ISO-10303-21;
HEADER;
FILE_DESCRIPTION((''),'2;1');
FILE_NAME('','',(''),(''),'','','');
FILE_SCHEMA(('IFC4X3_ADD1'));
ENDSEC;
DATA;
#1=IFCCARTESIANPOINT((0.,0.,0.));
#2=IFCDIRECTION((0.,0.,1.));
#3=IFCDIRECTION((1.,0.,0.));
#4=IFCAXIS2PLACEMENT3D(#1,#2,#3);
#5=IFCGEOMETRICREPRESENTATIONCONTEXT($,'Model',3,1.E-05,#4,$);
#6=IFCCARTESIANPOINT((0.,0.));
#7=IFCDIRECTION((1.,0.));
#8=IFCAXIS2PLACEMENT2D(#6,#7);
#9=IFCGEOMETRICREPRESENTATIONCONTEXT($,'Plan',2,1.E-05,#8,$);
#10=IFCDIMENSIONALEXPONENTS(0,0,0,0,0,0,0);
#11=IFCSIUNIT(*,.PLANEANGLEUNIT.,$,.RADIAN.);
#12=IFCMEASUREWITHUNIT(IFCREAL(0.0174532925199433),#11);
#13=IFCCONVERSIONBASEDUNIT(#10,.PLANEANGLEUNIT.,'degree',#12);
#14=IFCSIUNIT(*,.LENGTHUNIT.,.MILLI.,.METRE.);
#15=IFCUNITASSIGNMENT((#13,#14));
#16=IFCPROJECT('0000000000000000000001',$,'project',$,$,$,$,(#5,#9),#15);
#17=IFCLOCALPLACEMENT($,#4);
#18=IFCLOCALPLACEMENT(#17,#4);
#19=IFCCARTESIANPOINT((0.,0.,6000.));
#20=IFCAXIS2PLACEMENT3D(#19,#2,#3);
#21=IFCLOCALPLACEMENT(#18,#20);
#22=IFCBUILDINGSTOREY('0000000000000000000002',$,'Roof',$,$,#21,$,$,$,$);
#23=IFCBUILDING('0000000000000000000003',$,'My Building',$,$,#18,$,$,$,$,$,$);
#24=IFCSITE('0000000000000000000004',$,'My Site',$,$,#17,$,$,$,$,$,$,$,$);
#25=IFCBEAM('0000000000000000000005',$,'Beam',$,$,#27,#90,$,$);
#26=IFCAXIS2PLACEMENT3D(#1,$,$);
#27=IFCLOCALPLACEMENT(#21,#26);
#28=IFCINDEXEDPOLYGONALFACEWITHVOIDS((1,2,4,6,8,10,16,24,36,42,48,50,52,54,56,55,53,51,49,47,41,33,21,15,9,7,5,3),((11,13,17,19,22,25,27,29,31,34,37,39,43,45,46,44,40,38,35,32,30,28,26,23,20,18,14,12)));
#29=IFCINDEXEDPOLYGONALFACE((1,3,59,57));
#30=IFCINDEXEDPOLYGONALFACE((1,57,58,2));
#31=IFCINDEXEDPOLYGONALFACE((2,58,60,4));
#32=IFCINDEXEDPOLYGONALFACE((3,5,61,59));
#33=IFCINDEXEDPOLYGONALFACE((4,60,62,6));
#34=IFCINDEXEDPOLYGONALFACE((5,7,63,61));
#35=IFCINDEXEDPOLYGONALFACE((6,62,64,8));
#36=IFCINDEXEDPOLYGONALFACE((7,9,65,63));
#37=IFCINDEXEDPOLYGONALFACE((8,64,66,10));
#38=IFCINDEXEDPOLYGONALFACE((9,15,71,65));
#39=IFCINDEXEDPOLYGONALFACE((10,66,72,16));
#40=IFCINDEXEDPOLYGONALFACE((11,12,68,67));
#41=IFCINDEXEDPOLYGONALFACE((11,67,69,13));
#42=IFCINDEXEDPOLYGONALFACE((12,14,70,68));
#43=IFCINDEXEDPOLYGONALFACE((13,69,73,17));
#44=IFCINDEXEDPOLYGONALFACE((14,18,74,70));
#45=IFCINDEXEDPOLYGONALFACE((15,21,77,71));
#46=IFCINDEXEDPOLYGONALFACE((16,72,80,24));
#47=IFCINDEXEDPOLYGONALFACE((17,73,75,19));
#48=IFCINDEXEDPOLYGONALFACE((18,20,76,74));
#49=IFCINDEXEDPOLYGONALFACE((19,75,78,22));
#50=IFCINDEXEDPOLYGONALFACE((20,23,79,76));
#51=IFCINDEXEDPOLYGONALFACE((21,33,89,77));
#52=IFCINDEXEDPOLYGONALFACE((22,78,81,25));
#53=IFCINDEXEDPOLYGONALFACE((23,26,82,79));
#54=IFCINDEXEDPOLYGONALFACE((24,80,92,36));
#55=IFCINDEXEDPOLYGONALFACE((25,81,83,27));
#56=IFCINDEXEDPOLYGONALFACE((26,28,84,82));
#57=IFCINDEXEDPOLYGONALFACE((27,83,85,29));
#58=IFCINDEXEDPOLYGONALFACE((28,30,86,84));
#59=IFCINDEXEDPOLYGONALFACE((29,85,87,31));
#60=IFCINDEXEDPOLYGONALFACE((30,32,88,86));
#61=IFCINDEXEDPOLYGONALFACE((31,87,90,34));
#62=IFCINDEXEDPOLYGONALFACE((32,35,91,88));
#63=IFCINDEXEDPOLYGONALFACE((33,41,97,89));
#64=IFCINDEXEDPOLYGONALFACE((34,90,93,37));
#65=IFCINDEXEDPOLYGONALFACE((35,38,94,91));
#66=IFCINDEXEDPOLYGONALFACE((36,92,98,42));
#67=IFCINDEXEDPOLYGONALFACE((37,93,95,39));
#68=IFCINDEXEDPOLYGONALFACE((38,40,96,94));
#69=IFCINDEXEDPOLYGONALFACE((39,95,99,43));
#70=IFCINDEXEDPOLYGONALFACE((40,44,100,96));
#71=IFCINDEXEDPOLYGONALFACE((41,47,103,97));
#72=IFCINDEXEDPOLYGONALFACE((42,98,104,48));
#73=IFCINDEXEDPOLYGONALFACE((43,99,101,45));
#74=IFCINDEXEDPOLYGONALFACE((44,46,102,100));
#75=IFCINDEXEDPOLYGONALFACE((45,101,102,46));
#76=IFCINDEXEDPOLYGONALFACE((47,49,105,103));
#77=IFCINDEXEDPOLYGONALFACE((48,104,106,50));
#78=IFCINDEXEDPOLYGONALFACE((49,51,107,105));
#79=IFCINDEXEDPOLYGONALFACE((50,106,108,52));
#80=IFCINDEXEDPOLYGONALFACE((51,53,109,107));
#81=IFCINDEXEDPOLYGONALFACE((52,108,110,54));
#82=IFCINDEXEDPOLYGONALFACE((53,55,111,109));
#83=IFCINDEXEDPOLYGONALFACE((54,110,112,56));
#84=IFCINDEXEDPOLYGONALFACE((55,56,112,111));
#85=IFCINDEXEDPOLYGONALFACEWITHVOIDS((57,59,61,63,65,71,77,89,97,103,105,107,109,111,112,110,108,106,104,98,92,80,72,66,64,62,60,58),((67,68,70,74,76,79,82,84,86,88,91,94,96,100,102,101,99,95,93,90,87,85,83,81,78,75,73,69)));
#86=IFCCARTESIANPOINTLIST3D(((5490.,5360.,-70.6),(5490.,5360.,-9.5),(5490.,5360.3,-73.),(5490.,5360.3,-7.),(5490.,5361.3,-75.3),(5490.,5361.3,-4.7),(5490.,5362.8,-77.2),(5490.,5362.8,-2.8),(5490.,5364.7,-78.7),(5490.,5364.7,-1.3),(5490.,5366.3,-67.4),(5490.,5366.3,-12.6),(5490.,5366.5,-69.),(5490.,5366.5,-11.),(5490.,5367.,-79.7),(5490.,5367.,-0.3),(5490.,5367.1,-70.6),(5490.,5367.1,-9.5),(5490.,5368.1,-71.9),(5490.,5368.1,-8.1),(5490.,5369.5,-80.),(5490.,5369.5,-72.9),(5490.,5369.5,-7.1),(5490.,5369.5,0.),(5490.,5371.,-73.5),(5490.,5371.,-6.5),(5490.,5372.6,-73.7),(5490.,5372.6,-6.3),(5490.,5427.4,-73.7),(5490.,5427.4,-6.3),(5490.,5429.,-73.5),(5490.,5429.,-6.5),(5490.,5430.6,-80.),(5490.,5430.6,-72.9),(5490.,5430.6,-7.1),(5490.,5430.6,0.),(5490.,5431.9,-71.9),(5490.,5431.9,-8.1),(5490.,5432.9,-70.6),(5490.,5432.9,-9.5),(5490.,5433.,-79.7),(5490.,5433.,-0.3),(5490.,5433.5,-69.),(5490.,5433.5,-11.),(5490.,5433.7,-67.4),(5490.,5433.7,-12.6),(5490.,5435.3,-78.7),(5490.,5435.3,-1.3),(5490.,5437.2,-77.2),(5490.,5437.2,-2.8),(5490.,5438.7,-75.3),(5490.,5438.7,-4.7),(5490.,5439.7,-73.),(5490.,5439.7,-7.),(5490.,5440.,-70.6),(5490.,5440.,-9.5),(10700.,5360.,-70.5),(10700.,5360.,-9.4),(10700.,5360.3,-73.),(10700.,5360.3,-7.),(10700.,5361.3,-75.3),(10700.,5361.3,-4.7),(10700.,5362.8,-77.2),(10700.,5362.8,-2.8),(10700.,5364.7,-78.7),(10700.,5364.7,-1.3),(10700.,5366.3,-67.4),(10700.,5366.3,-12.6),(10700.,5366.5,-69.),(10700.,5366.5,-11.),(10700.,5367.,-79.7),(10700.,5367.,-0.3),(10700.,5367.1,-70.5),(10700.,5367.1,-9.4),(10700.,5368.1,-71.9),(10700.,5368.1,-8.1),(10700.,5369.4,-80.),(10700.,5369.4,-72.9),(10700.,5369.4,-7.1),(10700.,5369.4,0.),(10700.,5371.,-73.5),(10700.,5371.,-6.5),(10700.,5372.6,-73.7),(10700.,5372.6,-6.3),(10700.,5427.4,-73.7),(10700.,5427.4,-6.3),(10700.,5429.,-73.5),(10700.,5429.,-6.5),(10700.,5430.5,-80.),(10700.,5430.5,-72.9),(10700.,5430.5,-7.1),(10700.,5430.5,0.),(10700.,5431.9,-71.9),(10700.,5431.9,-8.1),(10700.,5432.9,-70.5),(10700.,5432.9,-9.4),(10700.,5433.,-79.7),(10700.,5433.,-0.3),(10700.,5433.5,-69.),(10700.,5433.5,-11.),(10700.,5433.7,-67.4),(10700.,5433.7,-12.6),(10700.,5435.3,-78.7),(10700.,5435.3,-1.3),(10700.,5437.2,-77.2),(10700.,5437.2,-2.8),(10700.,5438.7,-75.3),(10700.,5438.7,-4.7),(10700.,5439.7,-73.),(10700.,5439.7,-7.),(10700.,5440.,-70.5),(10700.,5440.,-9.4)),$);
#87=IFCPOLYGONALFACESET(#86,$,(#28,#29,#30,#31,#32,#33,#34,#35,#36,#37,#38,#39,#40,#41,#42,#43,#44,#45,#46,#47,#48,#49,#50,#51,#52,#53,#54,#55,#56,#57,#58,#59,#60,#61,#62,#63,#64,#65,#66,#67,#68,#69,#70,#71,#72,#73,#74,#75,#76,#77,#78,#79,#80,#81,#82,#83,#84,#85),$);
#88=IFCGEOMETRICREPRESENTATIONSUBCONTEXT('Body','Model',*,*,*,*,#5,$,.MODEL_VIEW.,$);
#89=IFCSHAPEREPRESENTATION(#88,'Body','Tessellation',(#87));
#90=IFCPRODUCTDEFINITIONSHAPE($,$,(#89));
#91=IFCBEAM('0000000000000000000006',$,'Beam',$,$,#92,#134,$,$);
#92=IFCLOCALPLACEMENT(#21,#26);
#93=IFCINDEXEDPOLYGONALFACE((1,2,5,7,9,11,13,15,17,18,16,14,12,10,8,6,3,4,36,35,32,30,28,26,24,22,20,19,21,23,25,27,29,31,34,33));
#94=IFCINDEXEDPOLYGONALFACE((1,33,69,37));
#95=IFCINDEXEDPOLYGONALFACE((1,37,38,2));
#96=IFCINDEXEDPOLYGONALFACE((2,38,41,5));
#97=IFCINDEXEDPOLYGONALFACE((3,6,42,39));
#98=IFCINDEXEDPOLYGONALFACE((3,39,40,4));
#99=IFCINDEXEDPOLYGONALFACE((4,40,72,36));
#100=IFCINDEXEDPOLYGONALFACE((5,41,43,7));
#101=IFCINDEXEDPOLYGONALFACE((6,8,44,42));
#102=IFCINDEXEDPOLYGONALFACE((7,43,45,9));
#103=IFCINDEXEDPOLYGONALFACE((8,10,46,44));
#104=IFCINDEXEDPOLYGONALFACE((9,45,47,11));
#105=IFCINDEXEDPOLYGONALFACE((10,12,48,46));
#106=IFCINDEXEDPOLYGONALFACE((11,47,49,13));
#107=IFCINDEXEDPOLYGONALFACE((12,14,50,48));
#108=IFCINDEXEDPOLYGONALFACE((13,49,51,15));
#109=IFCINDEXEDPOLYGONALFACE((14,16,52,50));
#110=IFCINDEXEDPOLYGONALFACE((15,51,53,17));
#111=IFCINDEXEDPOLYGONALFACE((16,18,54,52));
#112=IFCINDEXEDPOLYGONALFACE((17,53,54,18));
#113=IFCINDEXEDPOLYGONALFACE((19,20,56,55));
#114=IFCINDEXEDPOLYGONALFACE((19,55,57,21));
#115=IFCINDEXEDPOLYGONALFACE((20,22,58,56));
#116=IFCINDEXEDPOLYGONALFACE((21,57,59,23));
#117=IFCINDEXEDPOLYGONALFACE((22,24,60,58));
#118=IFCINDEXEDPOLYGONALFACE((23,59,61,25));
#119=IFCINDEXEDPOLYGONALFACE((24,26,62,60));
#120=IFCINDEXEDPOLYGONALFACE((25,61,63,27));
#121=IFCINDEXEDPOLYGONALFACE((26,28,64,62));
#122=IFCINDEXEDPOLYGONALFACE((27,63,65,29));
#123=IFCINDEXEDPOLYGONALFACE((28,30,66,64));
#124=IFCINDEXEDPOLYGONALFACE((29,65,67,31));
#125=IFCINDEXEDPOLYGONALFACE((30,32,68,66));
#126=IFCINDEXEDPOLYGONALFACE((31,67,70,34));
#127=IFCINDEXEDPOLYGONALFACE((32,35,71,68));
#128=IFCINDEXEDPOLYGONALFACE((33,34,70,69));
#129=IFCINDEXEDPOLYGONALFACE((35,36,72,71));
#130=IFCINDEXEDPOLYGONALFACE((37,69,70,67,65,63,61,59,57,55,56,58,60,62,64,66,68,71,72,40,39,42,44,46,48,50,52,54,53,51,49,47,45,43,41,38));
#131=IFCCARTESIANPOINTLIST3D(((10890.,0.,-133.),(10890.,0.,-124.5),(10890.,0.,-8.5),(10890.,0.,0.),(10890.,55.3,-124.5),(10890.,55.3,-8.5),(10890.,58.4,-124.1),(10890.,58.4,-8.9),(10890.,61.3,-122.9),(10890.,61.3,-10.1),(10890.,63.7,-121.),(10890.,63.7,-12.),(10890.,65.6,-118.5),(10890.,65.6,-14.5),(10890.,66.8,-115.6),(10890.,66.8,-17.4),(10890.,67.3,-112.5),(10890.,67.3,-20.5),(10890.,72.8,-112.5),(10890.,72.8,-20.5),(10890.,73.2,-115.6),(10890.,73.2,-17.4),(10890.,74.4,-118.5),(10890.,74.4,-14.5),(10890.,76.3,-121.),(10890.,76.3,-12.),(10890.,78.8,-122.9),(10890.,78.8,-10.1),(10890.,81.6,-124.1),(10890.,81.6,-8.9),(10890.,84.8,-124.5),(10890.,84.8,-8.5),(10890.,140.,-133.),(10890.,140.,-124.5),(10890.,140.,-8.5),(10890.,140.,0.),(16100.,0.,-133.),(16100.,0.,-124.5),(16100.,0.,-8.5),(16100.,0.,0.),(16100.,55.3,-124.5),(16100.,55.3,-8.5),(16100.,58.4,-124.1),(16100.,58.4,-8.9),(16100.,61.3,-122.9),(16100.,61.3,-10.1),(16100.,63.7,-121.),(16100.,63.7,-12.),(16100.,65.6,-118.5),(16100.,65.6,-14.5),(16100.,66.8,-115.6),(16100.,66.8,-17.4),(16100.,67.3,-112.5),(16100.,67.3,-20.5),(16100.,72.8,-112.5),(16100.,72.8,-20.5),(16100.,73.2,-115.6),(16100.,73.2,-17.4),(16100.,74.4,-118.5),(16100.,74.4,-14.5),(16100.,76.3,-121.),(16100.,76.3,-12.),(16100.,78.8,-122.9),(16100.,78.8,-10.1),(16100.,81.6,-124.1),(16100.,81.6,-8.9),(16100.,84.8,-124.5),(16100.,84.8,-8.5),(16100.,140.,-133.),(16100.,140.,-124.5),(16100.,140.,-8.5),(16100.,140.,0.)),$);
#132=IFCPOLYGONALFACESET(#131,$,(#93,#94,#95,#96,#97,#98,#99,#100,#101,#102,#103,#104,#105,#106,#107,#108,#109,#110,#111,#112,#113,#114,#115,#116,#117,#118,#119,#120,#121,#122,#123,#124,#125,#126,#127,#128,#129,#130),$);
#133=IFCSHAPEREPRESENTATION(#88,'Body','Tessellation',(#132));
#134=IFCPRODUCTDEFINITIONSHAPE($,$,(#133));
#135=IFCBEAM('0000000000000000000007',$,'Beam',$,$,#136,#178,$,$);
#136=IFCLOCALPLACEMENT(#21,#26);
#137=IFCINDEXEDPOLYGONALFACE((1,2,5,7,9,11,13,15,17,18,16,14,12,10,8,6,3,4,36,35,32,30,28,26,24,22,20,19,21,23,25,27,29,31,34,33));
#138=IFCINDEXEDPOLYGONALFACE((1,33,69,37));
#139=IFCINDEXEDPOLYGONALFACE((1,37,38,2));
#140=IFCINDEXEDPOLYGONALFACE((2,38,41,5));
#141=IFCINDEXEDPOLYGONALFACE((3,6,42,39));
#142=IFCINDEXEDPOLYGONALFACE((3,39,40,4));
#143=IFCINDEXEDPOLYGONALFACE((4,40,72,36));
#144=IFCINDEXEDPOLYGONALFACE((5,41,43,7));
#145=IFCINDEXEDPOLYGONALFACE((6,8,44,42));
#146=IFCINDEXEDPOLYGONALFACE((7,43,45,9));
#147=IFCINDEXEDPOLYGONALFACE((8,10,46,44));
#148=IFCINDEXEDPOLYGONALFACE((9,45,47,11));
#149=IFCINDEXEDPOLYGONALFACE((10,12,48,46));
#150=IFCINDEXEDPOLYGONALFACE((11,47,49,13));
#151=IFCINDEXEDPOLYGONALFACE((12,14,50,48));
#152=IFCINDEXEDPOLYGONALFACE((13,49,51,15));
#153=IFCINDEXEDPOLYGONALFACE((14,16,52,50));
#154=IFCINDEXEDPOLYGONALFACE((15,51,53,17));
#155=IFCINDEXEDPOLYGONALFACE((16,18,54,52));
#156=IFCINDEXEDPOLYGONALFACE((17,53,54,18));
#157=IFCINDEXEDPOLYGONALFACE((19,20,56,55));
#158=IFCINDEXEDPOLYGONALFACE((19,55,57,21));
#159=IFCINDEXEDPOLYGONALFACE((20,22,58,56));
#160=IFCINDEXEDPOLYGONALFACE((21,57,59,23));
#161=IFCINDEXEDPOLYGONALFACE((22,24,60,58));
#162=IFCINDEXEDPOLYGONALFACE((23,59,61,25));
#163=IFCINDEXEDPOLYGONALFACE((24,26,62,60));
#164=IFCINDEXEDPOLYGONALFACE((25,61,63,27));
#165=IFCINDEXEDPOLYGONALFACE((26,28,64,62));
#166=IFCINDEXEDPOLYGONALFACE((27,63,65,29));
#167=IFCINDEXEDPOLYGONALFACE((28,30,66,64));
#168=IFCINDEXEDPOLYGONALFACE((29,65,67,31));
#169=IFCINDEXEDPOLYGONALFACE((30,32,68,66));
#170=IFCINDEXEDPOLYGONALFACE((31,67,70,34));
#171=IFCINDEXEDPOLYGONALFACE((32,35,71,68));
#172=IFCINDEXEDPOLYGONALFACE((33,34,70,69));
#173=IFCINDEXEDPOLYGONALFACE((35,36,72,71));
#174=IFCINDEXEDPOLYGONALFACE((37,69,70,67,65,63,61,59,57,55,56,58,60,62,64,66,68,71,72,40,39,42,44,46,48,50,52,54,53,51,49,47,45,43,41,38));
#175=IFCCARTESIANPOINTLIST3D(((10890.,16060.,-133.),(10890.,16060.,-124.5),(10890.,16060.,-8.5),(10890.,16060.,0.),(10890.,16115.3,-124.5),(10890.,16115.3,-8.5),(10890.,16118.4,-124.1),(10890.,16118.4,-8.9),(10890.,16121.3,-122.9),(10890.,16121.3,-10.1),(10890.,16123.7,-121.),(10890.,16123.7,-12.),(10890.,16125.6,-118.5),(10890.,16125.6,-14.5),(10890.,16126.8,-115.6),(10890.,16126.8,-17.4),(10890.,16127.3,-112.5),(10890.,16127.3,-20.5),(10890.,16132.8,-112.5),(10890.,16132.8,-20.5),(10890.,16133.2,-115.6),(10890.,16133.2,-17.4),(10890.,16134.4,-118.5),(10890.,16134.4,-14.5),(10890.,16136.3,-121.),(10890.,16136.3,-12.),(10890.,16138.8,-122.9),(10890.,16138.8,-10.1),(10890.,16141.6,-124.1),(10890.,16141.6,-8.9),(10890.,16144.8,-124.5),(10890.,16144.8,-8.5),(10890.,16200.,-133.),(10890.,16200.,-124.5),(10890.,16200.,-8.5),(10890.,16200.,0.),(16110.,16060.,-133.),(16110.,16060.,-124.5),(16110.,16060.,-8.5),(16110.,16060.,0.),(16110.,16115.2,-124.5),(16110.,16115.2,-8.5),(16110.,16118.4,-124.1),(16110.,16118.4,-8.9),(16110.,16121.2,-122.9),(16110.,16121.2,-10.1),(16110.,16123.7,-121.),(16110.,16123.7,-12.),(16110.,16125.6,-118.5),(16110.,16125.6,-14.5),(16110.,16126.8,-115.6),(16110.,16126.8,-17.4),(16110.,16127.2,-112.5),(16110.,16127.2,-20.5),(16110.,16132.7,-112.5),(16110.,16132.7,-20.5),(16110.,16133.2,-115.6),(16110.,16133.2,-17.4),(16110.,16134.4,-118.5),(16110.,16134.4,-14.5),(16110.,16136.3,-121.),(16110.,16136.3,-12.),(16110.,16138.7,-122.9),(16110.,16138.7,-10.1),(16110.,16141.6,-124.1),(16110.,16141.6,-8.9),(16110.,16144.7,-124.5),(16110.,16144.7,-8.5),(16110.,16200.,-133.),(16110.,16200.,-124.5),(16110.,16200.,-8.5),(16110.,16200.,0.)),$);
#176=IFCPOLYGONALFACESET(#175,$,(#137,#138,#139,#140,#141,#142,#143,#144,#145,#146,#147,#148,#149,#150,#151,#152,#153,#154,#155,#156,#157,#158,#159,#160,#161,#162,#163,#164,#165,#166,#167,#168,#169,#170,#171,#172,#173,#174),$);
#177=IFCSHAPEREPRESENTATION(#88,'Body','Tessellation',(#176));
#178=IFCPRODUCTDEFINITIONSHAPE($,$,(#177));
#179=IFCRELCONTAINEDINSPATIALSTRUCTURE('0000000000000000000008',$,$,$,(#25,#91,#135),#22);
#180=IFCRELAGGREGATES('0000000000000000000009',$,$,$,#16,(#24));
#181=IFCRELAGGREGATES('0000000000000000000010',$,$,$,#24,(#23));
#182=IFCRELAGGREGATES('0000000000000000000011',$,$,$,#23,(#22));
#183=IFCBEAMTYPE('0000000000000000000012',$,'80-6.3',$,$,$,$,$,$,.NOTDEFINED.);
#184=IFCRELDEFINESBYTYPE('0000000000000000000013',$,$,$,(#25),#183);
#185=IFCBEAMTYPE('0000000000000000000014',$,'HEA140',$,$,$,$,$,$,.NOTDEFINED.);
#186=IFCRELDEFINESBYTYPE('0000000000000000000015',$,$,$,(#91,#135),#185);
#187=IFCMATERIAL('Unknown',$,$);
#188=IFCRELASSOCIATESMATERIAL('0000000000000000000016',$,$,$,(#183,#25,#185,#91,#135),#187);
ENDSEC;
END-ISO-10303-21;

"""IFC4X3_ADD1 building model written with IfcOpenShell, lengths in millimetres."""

from ifc_helpers import new_model, entity, si_unit, converted_unit, frame, origin_with_axes, origin_2d_with_axis, place, context, subcontext, project, spatial, hollow_rectangle, i_section, extrude, material, material_profile, profile_set, profile_usage, type_object, element, save


model = new_model("IFC4X3_ADD1")

# Units and contexts
model_context = context("Model", 3, precision=1e-05, world=origin_with_axes())
plan_context = context("Plan", 2, precision=1e-05, world=origin_2d_with_axis())
body_context = subcontext(model_context, "Body", "Model", "MODEL_VIEW")
ifc_project = project(units=[converted_unit("PLANEANGLEUNIT", "degree", entity("IfcReal", 0.0174532925199433), si_unit("PLANEANGLEUNIT", "RADIAN"), dimensions=[0, 0, 0, 0, 0, 0, 0]), si_unit("LENGTHUNIT", "METRE", prefix="MILLI")], contexts=[model_context, plan_context])

# Site, building, storey
site_placement = place(None, origin_with_axes())
site = spatial("IfcSite", under=ifc_project, at=site_placement, Name="My Site")
building_placement = place(site_placement, origin_with_axes())
building = spatial("IfcBuilding", under=site, at=building_placement, Name="My Building")
storey_placement = place(building_placement, frame((0.0, 0.0, 6000.0), z_axis=(0.0, 0.0, 1.0), x_axis=(1.0, 0.0, 0.0)))
storey = spatial("IfcBuildingStorey", under=building, at=storey_placement, Name="Roof")

# Beams
ifc_material = material(Name="Unknown")
ifc_material_profile_1 = material_profile(ifc_material, hollow_rectangle(XDim=80.0, YDim=80.0, WallThickness=6.3, InnerFilletRadius=6.3, OuterFilletRadius=9.4))
ifc_profile_set_1 = profile_set([ifc_material_profile_1])
beam_type_1 = type_object("IfcBeamType", Name="80-6.3", PredefinedType="NOTDEFINED", material=ifc_profile_set_1)
ifc_profile_usage_1 = profile_usage(ifc_profile_set_1, cardinal=8)
beam_1_placement = place(storey_placement, frame((5490.0, 5400.0, 0.0), z_axis=(1.0, 0.0, 0.0), x_axis=(0.0, 1.0, 0.0)))
element("IfcBeam", 1, at=beam_1_placement, inside=storey, type_object=beam_type_1, material=ifc_profile_usage_1, Name="Beam", context=body_context, shape_type="SweptSolid", body=[
    extrude(hollow_rectangle(XDim=80.0, YDim=80.0, WallThickness=6.3, InnerFilletRadius=6.3, OuterFilletRadius=9.4), frame((0.0, -40.0, 0.0), z_axis=(0.0, 0.0, 1.0), x_axis=(1.0, 0.0, 0.0)), (0.0, 0.0, 1.0), 5210.0),
])
ifc_material_profile_2 = material_profile(ifc_material, i_section(OverallWidth=140.0, OverallDepth=133.0, WebThickness=5.5, FlangeThickness=8.5, FilletRadius=12.0))
ifc_profile_set_2 = profile_set([ifc_material_profile_2])
ifc_profile_usage_2 = profile_usage(ifc_profile_set_2, cardinal=7)
beam_type_2 = type_object("IfcBeamType", Name="HEA140", PredefinedType="NOTDEFINED", material=ifc_profile_set_2)
beam_2_placement = place(storey_placement, frame((16100.0, 0.0, 0.0), z_axis=(-1.0, 0.0, 0.0), x_axis=(0.0, -1.0, 0.0)))
element("IfcBeam", 2, at=beam_2_placement, inside=storey, type_object=beam_type_2, material=ifc_profile_usage_2, Name="Beam", context=body_context, shape_type="SweptSolid", body=[
    extrude(i_section(OverallWidth=140.0, OverallDepth=133.0, WebThickness=5.5, FlangeThickness=8.5, FilletRadius=12.0), frame((-70.0, -66.5, 0.0), z_axis=(0.0, 0.0, 1.0), x_axis=(1.0, 0.0, 0.0)), (0.0, 0.0, 1.0), 5210.0),
])
ifc_profile_usage_3 = profile_usage(ifc_profile_set_2, cardinal=7)
beam_3_placement = place(storey_placement, frame((10890.0, 16200.0, 0.0), z_axis=(1.0, 0.0, 0.0), x_axis=(0.0, 1.0, 0.0)))
element("IfcBeam", 3, at=beam_3_placement, inside=storey, type_object=beam_type_2, material=ifc_profile_usage_3, Name="Beam", context=body_context, shape_type="SweptSolid", body=[
    extrude(i_section(OverallWidth=140.0, OverallDepth=133.0, WebThickness=5.5, FlangeThickness=8.5, FilletRadius=12.0), frame((-70.0, -66.5, 0.0), z_axis=(0.0, 0.0, 1.0), x_axis=(1.0, 0.0, 0.0)), (0.0, 0.0, 1.0), 5220.0),
])

save(model, "model.ifc")
